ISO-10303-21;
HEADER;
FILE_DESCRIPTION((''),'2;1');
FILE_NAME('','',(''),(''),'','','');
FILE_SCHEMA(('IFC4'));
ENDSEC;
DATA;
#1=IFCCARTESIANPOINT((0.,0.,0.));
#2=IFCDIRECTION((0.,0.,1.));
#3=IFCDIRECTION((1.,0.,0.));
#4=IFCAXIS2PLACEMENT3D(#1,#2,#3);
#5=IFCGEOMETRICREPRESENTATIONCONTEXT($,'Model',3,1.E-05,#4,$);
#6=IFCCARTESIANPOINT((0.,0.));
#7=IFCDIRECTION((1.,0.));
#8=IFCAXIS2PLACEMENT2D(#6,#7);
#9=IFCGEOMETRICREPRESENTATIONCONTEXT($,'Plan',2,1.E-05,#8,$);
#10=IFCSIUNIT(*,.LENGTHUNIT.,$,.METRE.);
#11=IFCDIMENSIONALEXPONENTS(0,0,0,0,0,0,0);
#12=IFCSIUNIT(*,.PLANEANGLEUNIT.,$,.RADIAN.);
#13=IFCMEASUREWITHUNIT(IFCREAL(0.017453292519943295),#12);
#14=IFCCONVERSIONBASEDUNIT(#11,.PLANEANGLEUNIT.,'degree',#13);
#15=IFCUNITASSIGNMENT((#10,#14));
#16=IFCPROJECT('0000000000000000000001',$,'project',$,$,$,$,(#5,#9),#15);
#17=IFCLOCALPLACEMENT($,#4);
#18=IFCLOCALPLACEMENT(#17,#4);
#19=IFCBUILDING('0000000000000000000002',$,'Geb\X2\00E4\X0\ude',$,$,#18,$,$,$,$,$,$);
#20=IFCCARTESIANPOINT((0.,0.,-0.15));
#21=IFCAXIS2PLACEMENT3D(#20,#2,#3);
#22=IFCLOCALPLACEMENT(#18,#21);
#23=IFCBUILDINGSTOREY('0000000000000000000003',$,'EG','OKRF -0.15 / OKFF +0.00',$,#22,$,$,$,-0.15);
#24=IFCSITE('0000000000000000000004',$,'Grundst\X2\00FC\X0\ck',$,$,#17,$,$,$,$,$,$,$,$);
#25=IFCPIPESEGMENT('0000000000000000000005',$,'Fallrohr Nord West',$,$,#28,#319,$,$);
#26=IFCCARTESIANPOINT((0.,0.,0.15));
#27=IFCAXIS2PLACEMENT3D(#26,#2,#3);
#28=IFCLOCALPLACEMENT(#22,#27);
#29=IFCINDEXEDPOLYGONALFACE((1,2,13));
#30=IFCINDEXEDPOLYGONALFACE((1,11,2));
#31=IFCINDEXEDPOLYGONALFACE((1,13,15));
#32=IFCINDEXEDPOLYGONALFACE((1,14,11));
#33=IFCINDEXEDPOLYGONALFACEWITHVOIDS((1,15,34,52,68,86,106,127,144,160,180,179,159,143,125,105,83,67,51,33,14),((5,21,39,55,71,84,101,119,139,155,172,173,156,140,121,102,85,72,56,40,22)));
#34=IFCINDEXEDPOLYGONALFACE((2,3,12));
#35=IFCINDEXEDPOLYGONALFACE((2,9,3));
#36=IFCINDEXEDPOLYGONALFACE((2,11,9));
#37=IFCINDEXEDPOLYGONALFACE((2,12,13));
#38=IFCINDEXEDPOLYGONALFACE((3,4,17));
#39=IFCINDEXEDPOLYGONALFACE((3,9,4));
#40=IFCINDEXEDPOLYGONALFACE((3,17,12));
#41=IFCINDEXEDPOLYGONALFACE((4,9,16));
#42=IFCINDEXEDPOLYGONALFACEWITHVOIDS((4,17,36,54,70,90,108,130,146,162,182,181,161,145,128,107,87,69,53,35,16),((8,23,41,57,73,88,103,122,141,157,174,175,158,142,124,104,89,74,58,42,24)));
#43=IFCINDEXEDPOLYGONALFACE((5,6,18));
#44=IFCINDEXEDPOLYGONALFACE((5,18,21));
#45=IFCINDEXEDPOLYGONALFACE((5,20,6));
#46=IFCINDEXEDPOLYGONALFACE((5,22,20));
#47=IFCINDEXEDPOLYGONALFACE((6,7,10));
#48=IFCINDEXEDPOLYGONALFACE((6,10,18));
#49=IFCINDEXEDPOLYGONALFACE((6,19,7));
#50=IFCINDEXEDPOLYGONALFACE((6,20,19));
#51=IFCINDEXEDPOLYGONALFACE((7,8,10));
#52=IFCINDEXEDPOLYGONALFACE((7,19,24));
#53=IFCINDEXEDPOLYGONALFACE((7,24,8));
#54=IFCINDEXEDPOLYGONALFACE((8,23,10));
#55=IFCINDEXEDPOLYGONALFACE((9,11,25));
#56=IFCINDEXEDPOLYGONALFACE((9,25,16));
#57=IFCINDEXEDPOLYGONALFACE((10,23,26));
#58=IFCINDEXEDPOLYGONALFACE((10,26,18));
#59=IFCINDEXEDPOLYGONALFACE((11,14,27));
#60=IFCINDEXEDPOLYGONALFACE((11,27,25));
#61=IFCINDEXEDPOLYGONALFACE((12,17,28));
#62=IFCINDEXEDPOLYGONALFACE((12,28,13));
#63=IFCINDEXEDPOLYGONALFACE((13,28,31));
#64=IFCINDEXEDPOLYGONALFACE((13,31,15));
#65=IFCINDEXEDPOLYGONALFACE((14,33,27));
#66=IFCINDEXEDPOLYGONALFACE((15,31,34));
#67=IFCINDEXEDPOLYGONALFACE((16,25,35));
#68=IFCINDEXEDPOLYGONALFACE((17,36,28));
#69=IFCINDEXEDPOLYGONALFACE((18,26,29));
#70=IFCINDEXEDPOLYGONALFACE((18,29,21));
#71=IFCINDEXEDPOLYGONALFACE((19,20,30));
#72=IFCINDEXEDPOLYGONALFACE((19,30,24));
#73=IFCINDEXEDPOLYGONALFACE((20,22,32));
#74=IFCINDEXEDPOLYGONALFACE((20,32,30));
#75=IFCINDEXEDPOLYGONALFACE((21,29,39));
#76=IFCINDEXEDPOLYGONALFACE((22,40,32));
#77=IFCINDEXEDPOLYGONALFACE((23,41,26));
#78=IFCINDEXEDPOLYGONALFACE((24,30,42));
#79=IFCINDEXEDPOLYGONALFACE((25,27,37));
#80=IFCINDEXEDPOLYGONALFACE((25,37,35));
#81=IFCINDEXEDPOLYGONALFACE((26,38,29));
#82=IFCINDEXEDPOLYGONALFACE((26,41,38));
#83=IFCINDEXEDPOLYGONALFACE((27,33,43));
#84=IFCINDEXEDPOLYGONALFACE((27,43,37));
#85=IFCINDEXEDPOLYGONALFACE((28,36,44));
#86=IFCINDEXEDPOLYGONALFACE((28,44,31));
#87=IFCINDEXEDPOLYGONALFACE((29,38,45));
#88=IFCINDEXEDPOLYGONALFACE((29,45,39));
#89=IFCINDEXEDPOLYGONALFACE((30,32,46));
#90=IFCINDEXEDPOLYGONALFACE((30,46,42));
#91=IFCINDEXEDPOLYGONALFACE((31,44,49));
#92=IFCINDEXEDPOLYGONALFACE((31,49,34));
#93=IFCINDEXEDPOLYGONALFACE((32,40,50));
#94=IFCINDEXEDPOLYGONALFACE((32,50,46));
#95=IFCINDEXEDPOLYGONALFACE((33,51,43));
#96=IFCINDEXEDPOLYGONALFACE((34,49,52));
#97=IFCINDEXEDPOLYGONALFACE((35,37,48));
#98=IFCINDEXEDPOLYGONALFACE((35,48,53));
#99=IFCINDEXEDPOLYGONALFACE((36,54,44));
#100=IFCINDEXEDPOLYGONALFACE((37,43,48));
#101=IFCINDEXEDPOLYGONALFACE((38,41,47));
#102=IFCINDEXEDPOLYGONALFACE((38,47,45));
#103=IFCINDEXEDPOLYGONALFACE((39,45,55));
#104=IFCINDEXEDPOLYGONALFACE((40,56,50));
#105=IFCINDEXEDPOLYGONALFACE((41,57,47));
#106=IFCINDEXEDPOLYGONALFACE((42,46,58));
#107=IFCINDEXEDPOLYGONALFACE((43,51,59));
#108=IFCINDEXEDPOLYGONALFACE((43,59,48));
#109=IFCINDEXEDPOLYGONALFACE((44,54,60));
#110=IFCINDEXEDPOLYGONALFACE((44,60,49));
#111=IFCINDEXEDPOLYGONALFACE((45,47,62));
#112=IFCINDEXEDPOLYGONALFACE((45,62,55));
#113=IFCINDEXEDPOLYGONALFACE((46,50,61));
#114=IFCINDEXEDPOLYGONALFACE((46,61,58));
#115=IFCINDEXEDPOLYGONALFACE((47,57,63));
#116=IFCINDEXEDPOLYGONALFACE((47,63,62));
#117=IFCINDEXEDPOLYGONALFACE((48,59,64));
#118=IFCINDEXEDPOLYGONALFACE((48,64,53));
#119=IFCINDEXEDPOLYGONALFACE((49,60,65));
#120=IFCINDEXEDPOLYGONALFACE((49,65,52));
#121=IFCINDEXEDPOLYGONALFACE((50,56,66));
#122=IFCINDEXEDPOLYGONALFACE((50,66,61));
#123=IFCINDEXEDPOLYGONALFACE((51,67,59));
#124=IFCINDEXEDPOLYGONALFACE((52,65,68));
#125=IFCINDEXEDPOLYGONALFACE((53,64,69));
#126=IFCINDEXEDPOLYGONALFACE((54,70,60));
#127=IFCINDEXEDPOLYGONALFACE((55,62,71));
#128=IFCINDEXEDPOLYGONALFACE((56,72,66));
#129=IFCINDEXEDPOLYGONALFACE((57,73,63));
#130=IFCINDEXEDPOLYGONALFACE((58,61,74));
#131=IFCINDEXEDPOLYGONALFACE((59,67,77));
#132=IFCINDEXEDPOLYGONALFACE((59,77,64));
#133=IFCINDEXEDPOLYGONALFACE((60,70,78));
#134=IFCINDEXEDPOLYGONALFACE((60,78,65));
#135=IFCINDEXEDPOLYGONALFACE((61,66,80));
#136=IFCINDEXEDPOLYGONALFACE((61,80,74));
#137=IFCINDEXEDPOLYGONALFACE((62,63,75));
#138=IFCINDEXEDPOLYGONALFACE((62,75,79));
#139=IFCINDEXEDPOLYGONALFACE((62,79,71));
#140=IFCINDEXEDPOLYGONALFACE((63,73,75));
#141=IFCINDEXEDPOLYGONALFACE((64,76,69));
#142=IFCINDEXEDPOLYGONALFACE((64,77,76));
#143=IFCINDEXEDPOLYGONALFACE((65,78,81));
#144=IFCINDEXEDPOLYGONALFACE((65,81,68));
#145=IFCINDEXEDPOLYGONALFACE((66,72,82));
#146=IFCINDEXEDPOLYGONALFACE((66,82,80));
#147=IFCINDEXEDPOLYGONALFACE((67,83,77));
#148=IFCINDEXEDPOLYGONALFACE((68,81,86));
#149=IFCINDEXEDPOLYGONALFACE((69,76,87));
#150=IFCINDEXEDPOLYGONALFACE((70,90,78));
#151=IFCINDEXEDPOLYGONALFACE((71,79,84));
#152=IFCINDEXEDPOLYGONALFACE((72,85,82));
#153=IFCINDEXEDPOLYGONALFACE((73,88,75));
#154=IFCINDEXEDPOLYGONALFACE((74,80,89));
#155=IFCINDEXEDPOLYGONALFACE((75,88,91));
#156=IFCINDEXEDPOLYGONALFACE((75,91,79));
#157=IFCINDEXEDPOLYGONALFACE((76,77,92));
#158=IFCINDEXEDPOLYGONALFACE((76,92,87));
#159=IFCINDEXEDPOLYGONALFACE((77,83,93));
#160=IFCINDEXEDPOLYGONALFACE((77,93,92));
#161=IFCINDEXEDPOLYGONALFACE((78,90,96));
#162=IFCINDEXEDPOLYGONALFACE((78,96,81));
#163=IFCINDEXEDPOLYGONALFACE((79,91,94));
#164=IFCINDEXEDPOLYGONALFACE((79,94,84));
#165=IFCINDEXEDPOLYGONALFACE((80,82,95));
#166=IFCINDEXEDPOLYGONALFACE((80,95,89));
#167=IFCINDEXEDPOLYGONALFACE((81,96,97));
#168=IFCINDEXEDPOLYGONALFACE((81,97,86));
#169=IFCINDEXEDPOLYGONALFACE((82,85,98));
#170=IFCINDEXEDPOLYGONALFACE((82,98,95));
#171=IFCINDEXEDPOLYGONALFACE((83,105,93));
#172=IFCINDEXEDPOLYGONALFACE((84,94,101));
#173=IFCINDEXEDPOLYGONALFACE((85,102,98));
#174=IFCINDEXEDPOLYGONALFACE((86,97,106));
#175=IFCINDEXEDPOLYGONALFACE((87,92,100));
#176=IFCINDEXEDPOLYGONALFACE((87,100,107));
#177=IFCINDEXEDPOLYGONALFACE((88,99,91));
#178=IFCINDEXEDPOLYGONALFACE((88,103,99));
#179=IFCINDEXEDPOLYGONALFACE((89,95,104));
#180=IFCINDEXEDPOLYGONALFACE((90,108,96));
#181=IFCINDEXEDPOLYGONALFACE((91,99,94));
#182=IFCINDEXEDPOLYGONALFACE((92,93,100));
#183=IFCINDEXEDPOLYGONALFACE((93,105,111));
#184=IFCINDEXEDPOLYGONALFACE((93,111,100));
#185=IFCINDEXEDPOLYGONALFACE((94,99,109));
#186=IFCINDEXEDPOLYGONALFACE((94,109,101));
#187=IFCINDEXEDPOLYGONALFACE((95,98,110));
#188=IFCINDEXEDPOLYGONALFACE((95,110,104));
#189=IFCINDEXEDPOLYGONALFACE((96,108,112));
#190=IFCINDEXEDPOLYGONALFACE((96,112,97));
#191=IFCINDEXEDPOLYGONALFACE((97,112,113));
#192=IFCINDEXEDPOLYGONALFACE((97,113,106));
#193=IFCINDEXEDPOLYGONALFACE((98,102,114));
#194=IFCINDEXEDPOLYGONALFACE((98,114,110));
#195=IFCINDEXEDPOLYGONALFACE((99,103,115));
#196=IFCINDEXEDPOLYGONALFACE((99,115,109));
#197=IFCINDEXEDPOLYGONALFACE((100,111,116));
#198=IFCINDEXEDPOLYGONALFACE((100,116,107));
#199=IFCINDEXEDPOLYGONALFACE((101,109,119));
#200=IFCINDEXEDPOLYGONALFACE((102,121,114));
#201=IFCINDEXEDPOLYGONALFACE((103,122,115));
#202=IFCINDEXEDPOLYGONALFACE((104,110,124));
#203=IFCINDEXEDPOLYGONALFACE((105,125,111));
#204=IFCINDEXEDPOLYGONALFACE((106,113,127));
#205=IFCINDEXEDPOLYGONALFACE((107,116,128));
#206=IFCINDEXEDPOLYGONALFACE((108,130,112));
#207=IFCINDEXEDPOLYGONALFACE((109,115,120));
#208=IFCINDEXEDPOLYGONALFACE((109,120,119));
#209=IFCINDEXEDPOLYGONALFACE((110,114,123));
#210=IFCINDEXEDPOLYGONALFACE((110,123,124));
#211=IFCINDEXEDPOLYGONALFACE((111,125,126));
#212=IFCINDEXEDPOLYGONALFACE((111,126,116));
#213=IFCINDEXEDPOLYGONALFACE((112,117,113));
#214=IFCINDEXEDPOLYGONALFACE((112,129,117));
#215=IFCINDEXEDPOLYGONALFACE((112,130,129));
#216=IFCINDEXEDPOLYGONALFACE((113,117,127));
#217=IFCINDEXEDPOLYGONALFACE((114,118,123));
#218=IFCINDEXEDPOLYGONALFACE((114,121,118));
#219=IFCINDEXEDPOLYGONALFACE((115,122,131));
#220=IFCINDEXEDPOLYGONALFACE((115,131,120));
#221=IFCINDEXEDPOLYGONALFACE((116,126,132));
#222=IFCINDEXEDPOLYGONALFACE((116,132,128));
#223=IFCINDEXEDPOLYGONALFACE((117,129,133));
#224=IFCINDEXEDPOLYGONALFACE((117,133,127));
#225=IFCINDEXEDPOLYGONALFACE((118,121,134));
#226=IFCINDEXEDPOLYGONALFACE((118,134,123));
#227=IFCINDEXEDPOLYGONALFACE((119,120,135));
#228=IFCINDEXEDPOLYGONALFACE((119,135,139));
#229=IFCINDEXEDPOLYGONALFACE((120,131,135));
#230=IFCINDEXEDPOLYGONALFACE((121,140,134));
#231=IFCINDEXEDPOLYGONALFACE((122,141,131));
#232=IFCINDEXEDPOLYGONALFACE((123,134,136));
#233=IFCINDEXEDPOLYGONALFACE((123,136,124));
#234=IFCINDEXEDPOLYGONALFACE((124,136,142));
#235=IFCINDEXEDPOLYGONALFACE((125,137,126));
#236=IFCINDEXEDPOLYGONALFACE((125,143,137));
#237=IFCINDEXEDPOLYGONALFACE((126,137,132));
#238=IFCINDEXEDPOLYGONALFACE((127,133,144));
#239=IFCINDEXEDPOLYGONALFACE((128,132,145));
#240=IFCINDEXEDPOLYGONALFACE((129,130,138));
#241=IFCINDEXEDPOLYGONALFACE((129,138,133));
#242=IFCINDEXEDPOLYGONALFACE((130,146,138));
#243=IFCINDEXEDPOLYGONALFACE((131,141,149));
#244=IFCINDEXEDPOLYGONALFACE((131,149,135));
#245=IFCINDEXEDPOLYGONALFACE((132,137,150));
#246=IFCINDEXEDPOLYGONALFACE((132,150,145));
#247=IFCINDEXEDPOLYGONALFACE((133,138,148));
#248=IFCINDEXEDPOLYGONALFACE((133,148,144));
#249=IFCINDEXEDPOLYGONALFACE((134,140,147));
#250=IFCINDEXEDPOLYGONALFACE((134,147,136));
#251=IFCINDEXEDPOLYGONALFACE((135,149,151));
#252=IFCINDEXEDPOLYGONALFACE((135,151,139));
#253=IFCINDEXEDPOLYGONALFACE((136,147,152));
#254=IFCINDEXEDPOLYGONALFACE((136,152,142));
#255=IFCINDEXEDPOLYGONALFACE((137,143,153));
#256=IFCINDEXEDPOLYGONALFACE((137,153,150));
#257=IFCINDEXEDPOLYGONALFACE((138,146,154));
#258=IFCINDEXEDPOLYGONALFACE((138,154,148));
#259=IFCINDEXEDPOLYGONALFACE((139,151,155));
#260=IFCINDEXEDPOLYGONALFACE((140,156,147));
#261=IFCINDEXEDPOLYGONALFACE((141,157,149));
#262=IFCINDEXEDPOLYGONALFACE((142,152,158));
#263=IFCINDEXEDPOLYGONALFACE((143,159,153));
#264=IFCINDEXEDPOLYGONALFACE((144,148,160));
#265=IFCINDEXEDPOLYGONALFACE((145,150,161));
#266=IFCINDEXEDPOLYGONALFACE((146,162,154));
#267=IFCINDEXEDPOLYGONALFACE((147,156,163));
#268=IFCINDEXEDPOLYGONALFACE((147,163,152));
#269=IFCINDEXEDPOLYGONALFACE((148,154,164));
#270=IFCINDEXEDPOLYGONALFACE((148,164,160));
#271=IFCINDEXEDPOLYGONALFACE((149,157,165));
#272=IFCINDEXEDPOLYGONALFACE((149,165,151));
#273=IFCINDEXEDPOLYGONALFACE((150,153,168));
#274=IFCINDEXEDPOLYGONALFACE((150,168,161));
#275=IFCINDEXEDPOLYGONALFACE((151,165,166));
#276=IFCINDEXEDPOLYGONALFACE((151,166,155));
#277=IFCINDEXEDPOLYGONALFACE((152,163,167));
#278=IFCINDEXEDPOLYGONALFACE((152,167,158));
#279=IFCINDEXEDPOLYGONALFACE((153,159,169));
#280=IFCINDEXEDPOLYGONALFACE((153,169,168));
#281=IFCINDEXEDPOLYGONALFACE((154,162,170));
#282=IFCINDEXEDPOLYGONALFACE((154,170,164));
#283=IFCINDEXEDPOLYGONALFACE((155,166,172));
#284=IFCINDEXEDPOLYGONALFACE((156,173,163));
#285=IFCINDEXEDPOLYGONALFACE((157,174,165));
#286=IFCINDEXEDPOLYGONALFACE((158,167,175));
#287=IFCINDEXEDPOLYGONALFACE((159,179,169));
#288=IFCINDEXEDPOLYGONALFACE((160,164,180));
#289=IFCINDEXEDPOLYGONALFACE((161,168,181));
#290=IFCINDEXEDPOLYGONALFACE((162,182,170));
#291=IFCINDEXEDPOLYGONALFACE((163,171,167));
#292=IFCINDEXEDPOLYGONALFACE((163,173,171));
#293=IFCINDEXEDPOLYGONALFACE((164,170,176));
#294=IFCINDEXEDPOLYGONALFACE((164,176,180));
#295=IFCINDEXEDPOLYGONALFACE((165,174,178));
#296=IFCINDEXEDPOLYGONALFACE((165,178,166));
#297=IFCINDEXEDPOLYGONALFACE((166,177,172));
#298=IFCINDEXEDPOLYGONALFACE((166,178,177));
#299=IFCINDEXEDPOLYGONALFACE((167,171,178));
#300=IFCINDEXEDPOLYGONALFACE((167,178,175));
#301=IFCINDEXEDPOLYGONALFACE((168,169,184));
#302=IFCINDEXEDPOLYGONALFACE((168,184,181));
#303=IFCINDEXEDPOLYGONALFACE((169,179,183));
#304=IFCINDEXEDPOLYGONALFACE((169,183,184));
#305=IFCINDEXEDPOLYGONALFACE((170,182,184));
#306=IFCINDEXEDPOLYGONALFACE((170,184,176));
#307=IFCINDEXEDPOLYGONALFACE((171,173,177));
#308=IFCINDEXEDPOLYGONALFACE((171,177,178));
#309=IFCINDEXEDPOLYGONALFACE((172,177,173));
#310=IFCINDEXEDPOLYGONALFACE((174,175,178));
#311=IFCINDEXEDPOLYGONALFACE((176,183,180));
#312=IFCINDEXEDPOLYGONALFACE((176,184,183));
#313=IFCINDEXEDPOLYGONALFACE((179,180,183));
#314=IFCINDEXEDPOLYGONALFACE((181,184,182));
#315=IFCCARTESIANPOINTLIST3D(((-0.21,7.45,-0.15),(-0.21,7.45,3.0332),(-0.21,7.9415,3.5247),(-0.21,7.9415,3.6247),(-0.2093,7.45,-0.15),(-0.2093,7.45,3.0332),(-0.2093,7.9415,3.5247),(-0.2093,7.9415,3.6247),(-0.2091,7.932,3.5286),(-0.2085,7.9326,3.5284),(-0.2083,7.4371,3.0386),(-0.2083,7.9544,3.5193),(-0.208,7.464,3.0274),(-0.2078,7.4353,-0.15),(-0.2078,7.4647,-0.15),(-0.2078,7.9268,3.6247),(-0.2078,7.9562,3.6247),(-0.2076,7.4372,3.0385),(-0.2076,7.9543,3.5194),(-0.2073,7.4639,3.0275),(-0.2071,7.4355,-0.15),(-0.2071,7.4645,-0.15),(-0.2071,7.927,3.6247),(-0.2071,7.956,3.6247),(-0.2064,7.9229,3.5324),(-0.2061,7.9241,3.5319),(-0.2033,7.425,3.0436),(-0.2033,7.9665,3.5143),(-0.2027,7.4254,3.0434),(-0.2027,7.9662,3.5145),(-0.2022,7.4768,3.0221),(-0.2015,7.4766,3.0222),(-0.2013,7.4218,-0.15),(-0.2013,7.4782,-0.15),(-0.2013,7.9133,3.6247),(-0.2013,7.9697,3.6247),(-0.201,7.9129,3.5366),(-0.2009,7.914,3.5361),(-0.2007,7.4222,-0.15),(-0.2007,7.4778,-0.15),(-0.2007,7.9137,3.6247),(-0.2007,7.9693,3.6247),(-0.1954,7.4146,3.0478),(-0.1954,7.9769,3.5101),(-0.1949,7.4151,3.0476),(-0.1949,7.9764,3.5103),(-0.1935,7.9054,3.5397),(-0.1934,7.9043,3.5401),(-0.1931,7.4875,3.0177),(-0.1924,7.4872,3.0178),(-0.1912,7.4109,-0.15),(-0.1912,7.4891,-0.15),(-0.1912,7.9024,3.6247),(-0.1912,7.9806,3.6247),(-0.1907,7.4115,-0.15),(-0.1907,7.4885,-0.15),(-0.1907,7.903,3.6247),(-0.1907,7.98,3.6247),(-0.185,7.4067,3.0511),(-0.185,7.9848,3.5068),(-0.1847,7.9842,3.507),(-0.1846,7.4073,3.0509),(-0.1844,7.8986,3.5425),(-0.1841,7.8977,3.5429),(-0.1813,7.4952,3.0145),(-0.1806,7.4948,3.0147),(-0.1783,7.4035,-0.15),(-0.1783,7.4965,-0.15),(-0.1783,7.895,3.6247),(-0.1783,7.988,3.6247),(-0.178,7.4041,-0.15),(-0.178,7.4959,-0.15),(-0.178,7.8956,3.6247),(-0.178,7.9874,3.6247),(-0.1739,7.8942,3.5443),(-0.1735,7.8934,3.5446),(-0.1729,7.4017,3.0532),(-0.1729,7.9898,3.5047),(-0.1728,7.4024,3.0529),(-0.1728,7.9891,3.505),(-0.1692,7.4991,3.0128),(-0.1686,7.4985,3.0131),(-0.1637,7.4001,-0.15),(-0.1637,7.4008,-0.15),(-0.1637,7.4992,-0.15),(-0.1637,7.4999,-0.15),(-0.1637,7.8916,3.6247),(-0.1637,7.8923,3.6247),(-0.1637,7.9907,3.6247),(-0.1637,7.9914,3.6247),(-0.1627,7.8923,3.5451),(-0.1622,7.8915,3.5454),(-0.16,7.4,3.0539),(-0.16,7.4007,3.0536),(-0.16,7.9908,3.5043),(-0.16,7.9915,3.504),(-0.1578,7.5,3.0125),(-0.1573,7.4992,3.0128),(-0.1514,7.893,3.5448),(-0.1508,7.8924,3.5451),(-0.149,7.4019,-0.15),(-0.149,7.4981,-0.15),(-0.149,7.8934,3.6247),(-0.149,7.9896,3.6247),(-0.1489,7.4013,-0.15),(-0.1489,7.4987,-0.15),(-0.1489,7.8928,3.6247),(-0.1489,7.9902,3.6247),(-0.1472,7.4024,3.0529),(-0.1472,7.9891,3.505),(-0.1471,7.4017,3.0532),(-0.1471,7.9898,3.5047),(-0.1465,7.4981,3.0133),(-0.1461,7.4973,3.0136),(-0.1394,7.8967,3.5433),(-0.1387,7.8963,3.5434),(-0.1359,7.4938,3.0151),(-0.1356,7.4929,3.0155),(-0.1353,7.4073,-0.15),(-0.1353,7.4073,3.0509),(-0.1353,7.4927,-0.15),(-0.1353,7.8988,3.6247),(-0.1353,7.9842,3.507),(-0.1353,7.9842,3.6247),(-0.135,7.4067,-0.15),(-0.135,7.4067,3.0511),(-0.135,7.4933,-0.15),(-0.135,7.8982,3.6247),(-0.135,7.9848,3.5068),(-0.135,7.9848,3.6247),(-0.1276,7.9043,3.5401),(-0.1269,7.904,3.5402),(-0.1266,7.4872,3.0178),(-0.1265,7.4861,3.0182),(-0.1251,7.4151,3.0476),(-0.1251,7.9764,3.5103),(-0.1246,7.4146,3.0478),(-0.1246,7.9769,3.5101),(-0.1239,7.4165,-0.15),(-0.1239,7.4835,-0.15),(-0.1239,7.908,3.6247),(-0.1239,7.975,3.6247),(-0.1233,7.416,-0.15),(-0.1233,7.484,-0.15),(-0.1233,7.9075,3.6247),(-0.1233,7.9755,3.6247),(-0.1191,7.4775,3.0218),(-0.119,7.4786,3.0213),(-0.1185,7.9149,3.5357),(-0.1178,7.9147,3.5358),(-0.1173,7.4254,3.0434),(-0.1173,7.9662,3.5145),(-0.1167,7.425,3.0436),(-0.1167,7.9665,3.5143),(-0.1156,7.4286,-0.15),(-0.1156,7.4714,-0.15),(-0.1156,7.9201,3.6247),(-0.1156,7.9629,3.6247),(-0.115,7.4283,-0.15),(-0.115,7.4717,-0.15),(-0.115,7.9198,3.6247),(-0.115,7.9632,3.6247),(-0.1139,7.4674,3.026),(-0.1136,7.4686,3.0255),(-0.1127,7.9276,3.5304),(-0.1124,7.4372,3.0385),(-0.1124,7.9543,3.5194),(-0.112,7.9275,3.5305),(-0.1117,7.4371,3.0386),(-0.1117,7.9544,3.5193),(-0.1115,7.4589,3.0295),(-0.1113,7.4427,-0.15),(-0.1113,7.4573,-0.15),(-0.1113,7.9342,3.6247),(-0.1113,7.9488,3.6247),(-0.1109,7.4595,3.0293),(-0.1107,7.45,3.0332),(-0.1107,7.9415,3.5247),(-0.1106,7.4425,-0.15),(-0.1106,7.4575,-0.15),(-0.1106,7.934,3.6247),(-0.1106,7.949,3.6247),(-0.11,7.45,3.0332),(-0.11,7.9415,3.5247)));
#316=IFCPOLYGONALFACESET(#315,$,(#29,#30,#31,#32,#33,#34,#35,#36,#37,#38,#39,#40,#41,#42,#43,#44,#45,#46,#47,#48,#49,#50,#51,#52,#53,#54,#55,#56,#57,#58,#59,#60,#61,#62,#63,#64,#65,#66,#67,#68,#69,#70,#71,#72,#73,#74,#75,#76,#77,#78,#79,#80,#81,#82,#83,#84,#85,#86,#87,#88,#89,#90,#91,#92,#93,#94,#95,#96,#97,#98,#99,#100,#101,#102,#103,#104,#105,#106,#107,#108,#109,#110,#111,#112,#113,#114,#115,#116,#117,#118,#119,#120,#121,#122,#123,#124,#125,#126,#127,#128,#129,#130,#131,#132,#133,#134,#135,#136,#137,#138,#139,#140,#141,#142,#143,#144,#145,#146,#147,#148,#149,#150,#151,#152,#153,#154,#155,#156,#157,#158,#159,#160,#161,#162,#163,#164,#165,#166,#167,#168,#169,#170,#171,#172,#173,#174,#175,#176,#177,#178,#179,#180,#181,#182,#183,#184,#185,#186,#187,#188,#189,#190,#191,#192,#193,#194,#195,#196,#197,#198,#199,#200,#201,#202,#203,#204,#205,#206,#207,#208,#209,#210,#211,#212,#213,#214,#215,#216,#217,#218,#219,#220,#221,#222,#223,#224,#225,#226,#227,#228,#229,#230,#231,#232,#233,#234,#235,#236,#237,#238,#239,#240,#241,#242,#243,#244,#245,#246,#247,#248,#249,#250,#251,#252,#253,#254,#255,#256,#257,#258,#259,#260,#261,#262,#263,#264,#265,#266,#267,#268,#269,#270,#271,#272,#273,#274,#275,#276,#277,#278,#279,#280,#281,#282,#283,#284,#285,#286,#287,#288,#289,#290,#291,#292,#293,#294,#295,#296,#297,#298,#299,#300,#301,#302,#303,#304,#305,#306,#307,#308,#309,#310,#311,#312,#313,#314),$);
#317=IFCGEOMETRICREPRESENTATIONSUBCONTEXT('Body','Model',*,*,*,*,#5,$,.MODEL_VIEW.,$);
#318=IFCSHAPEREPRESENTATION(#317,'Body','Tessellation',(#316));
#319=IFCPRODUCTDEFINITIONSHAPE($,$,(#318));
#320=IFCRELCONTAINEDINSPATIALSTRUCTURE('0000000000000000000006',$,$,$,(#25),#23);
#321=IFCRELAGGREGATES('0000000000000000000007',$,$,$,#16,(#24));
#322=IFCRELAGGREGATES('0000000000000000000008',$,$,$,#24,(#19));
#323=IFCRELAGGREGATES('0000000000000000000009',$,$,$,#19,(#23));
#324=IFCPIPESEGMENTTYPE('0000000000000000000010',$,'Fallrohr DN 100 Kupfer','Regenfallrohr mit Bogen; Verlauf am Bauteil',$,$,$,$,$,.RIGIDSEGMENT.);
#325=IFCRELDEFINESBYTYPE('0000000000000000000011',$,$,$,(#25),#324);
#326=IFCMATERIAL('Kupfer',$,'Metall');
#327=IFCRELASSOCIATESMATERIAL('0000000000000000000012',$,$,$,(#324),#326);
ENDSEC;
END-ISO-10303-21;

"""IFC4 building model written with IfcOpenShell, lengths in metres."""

from ifc_helpers import new_model, entity, si_unit, converted_unit, frame, origin_with_axes, origin_2d_with_axis, place, context, subcontext, project, spatial, material, type_object, element, save


model = new_model("IFC4")

# Units and contexts
model_context = context("Model", 3, precision=1e-05, world=origin_with_axes())
plan_context = context("Plan", 2, precision=1e-05, world=origin_2d_with_axis())
body_context = subcontext(model_context, "Body", "Model", "MODEL_VIEW")
ifc_project = project(units=[si_unit("LENGTHUNIT", "METRE"), converted_unit("PLANEANGLEUNIT", "degree", entity("IfcReal", 0.017453292519943295), si_unit("PLANEANGLEUNIT", "RADIAN"), dimensions=[0, 0, 0, 0, 0, 0, 0])], contexts=[model_context, plan_context])

# Site, building, storey
site_placement = place(None, origin_with_axes())
site = spatial("IfcSite", under=ifc_project, at=site_placement, Name="Grundstück")
building_placement = place(site_placement, origin_with_axes())
building = spatial("IfcBuilding", under=site, at=building_placement, Name="Gebäude")
storey_placement = place(building_placement, frame((0.0, 0.0, -0.15), z_axis=(0.0, 0.0, 1.0), x_axis=(1.0, 0.0, 0.0)))
storey = spatial("IfcBuildingStorey", under=building, at=storey_placement, Name="EG", Description="OKRF -0.15 / OKFF +0.00", Elevation=-0.15)

# Pipe segment
ifc_material_1 = material(Name="Kupfer", Category="Metall")
pipe_segment_type = type_object("IfcPipeSegmentType", Name="Fallrohr DN 100 Kupfer", Description="Regenfallrohr mit Bogen; Verlauf am Bauteil", PredefinedType="RIGIDSEGMENT", material=ifc_material_1)
pipe_segment_1_placement = place(storey_placement, frame((0.0, 0.0, 0.15), z_axis=(0.0, 0.0, 1.0), x_axis=(1.0, 0.0, 0.0)))
element("IfcPipeSegment", 1, at=pipe_segment_1_placement, inside=storey, type_object=pipe_segment_type, Name="Fallrohr Nord West", context=body_context, shape_type="AdvancedSweptSolid", body=[
    entity("IfcSweptDiskSolid", entity("IfcPolyline", [entity("IfcCartesianPoint", [-0.16, 7.9415, 3.6247]), entity("IfcCartesianPoint", [-0.16, 7.9415, 3.5247]), entity("IfcCartesianPoint", [-0.16, 7.45, 3.0332]), entity("IfcCartesianPoint", [-0.16, 7.45, -0.15])]), 0.05, 0.0493),
])

save(model, "model.ifc")
